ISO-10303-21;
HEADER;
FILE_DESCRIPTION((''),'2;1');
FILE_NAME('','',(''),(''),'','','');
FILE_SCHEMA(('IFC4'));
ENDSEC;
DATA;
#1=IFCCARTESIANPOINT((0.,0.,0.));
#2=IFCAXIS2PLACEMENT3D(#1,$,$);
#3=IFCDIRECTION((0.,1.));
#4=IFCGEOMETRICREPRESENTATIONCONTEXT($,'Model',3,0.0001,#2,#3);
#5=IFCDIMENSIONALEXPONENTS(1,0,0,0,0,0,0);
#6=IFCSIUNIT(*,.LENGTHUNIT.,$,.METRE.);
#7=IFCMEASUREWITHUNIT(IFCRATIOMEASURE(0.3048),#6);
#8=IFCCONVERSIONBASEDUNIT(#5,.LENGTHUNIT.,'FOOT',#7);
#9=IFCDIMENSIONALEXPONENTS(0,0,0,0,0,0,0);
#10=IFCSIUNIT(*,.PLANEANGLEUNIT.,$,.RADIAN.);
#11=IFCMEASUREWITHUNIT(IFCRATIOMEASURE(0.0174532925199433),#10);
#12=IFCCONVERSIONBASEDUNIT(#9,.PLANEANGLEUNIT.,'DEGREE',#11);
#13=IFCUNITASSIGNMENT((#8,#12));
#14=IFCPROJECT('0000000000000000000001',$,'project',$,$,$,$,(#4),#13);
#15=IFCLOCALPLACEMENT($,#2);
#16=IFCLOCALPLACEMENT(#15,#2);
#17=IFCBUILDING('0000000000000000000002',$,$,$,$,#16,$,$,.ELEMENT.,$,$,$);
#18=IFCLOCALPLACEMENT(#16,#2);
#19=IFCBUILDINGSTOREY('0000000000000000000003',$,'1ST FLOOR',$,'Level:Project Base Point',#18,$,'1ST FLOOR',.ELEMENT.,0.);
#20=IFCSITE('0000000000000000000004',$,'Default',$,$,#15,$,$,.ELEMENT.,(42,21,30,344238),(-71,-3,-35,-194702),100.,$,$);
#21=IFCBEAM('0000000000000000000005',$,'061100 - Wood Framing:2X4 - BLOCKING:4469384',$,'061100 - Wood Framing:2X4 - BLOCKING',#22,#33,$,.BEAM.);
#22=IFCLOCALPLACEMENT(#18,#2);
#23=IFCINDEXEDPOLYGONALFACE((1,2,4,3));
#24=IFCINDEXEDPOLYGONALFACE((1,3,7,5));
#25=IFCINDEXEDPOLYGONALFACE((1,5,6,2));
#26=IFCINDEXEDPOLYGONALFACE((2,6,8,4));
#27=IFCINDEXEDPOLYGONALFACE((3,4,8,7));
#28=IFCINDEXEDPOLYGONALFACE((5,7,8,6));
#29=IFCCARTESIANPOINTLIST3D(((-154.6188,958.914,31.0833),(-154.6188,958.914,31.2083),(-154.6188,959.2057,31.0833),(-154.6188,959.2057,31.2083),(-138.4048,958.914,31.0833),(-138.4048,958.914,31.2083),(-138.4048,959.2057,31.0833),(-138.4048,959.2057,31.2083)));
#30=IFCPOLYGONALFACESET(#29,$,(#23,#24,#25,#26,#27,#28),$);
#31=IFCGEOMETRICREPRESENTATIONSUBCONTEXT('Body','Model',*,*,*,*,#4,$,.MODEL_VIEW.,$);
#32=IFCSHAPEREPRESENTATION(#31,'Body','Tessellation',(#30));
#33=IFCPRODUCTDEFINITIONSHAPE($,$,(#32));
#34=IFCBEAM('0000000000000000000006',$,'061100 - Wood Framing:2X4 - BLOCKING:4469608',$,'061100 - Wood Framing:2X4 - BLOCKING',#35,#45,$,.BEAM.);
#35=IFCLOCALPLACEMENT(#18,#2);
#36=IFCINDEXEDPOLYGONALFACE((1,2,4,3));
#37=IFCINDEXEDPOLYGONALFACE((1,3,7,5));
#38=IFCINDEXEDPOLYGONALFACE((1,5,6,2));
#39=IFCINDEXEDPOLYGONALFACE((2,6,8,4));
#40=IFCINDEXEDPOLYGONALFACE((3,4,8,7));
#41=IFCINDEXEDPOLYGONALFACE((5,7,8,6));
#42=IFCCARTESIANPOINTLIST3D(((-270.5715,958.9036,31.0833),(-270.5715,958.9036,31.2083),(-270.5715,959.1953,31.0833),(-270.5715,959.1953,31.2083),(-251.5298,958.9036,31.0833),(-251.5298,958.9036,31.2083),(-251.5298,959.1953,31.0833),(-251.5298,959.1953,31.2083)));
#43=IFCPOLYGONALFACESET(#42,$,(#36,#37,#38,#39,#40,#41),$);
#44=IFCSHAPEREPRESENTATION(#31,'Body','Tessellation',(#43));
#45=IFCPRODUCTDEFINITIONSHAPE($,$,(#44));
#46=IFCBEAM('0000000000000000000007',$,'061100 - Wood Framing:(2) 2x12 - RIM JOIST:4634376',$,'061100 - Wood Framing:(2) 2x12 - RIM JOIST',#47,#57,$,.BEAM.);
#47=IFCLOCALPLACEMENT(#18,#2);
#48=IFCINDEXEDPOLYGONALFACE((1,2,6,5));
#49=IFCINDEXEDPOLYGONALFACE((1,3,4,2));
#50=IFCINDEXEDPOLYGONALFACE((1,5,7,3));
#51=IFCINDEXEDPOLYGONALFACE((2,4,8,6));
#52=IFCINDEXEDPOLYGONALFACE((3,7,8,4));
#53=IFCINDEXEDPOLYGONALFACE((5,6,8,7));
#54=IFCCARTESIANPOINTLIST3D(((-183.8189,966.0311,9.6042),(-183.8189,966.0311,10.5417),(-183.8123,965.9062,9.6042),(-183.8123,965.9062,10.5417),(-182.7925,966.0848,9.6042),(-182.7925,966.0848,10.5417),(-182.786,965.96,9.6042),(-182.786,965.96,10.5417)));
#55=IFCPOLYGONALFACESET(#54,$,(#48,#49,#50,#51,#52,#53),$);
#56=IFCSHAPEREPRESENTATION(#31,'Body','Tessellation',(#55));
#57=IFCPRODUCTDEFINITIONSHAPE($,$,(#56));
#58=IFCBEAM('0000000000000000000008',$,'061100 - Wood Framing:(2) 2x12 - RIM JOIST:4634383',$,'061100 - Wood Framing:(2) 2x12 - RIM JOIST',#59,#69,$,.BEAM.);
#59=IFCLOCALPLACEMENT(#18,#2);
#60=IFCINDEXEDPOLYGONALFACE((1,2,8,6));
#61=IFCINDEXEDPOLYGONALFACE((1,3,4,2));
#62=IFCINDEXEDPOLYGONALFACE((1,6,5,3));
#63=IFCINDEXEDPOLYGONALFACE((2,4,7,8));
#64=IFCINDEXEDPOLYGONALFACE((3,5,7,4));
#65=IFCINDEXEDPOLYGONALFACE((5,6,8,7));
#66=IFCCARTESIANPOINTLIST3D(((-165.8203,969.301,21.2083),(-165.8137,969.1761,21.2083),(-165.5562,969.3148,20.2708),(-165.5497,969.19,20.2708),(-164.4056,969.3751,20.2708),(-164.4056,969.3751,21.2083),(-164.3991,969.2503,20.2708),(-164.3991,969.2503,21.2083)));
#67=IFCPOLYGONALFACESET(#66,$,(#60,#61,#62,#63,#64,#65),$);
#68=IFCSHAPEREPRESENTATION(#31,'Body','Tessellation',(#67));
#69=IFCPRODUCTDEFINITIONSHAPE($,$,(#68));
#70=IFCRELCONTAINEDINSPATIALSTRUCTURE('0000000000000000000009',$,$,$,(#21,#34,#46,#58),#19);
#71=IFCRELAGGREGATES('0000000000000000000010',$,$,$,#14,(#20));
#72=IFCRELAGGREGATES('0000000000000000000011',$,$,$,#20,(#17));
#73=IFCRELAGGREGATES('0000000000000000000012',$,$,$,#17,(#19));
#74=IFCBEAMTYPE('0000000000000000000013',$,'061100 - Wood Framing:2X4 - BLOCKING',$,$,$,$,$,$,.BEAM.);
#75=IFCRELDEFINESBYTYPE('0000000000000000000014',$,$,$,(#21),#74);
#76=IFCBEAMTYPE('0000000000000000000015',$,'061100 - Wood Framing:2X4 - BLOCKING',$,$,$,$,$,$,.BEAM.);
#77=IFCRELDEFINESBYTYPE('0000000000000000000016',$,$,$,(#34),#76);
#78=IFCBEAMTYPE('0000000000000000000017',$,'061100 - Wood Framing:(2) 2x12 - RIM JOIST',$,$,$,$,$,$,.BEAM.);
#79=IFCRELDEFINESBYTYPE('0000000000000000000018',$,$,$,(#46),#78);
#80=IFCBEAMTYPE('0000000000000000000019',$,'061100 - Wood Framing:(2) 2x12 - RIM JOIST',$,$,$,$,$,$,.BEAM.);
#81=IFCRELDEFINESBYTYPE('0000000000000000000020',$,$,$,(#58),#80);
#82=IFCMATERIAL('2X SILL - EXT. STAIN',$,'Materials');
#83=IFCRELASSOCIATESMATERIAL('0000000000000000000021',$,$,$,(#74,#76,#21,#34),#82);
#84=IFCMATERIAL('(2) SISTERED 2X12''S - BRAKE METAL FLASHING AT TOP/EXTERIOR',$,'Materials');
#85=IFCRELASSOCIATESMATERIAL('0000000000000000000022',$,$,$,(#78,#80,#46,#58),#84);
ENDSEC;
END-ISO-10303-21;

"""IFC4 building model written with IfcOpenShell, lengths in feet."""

from ifc_helpers import new_model, entity, si_unit, converted_unit, direction, frame, frame_2d, origin, origin_2d_with_axis, place, context, subcontext, project, spatial, rectangle, extrude, clip, halfspace, source, transform, mapped, material, material_profile, profile_set, profile_usage, type_object, type_shapes, element, save


model = new_model("IFC4")

# Units and contexts
model_context = context("Model", 3, precision=0.0001, world=origin(), true_north=direction((0.0, 1.0)))
body_context = subcontext(model_context, "Body", "Model", "MODEL_VIEW")
ifc_project = project(units=[converted_unit("LENGTHUNIT", "FOOT", entity("IfcRatioMeasure", 0.3048), si_unit("LENGTHUNIT", "METRE"), dimensions=[1, 0, 0, 0, 0, 0, 0]), converted_unit("PLANEANGLEUNIT", "DEGREE", entity("IfcRatioMeasure", 0.0174532925199433), si_unit("PLANEANGLEUNIT", "RADIAN"), dimensions=[0, 0, 0, 0, 0, 0, 0])], contexts=[model_context])

# Site, building, storey
site_placement = place(None, origin())
site = spatial("IfcSite", under=ifc_project, at=site_placement, Name="Default", CompositionType="ELEMENT", RefLatitude=(42, 21, 30, 344238), RefLongitude=(-71, -3, -35, -194702), RefElevation=100.0)
building_placement = place(site_placement, origin())
building = spatial("IfcBuilding", under=site, at=building_placement, CompositionType="ELEMENT")
storey_placement = place(building_placement, origin())
storey = spatial("IfcBuildingStorey", under=building, at=storey_placement, Name="1ST FLOOR", ObjectType="Level:Project Base Point", LongName="1ST FLOOR", CompositionType="ELEMENT", Elevation=0.0)

# Beams
ifc_material_1 = material(Name="2X SILL - EXT. STAIN", Category="Materials")
ifc_material_profile_1 = material_profile(ifc_material_1, rectangle(XDim=0.125, YDim=0.2917, at=origin_2d_with_axis()), Name="2X4 - BLOCKING")
ifc_profile_set_1 = profile_set([ifc_material_profile_1], Name="2X4 - BLOCKING")
ifc_profile_usage_1 = profile_usage(ifc_profile_set_1, cardinal=8)
beam_type_1 = type_object("IfcBeamType", Name="061100 - Wood Framing:2X4 - BLOCKING", PredefinedType="BEAM", material=ifc_profile_set_1)
shared_shape_1 = source(origin(), body_context, "Body", "SweptSolid", [
    extrude(rectangle(XDim=0.125, YDim=0.2917, at=frame_2d((0.0, 0.0), x_axis=(1.0, 0.0))), frame((-154.6188, 959.0599, 31.1458), z_axis=(1.0, 0.0, 0.0), x_axis=(0.0, 0.0, -1.0)), (0.0, 0.0, 1.0), 16.2139),
])
type_shapes(beam_type_1, [shared_shape_1])
beam_1_placement = place(storey_placement, origin())
element("IfcBeam", 1, at=beam_1_placement, inside=storey, type_object=beam_type_1, material=ifc_profile_usage_1, Name="061100 - Wood Framing:2X4 - BLOCKING:4469384", ObjectType="061100 - Wood Framing:2X4 - BLOCKING", PredefinedType="BEAM", context=body_context, shape_type="MappedRepresentation", body=[
    mapped(shared_shape_1, transform((0.0, 0.0, 0.0), scale=1.0)),
])
ifc_profile_usage_2 = profile_usage(ifc_profile_set_1, cardinal=8)
beam_type_2 = type_object("IfcBeamType", Name="061100 - Wood Framing:2X4 - BLOCKING", PredefinedType="BEAM", material=ifc_profile_set_1)
shared_shape_2 = source(origin(), body_context, "Body", "SweptSolid", [
    extrude(rectangle(XDim=0.125, YDim=0.2917, at=frame_2d((0.0, 0.0), x_axis=(1.0, 0.0))), frame((-270.5715, 959.0494, 31.1458), z_axis=(1.0, 0.0, 0.0), x_axis=(0.0, 0.0, -1.0)), (0.0, 0.0, 1.0), 19.0417),
])
type_shapes(beam_type_2, [shared_shape_2])
beam_2_placement = place(storey_placement, origin())
element("IfcBeam", 2, at=beam_2_placement, inside=storey, type_object=beam_type_2, material=ifc_profile_usage_2, Name="061100 - Wood Framing:2X4 - BLOCKING:4469608", ObjectType="061100 - Wood Framing:2X4 - BLOCKING", PredefinedType="BEAM", context=body_context, shape_type="MappedRepresentation", body=[
    mapped(shared_shape_2, transform((0.0, 0.0, 0.0), scale=1.0)),
])
ifc_material_2 = material(Name="(2) SISTERED 2X12'S - BRAKE METAL FLASHING AT TOP/EXTERIOR", Category="Materials")
ifc_material_profile_2 = material_profile(ifc_material_2, rectangle(XDim=0.9375, YDim=0.125, at=frame_2d((0.0, 0.0), x_axis=(1.0, 0.0))), Name="(2) 2x12 - RIM JOIST")
ifc_profile_set_2 = profile_set([ifc_material_profile_2], Name="(2) 2x12 - RIM JOIST")
ifc_profile_usage_3 = profile_usage(ifc_profile_set_2, cardinal=2)
beam_type_3 = type_object("IfcBeamType", Name="061100 - Wood Framing:(2) 2x12 - RIM JOIST", PredefinedType="BEAM", material=ifc_profile_set_2)
shared_shape_3 = source(origin(), body_context, "Body", "SweptSolid", [
    extrude(rectangle(XDim=0.9375, YDim=0.125, at=origin_2d_with_axis()), frame((-183.8156, 965.9686, 10.0729), z_axis=(0.99863, 0.052336, 0.0), x_axis=(0.0, 0.0, 1.0)), (0.0, 0.0, 1.0), 1.0278),
])
type_shapes(beam_type_3, [shared_shape_3])
beam_3_placement = place(storey_placement, origin())
element("IfcBeam", 3, at=beam_3_placement, inside=storey, type_object=beam_type_3, material=ifc_profile_usage_3, Name="061100 - Wood Framing:(2) 2x12 - RIM JOIST:4634376", ObjectType="061100 - Wood Framing:(2) 2x12 - RIM JOIST", PredefinedType="BEAM", context=body_context, shape_type="MappedRepresentation", body=[
    mapped(shared_shape_3, transform((0.0, 0.0, 0.0), scale=1.0)),
])
ifc_profile_usage_4 = profile_usage(ifc_profile_set_2, cardinal=2)
beam_type_4 = type_object("IfcBeamType", Name="061100 - Wood Framing:(2) 2x12 - RIM JOIST", PredefinedType="BEAM", material=ifc_profile_set_2)
shared_shape_4 = source(origin(), body_context, "Body", "Clipping", [
    clip(extrude(rectangle(XDim=0.9375, YDim=0.125, at=frame_2d((0.0, 0.0), x_axis=(1.0, 0.0))), frame((-165.817, 969.2386, 20.7396), z_axis=(0.99863, 0.052336, 0.0), x_axis=(0.0, 0.0, 1.0)), (0.0, 0.0, 1.0), 1.4166), halfspace(frame((-165.2632, 966.0702, 19.8354), z_axis=(-0.961136, -0.050371, -0.27144), x_axis=(0.271068, 0.014206, -0.962455)), False)),
])
type_shapes(beam_type_4, [shared_shape_4])
beam_4_placement = place(storey_placement, origin())
element("IfcBeam", 4, at=beam_4_placement, inside=storey, type_object=beam_type_4, material=ifc_profile_usage_4, Name="061100 - Wood Framing:(2) 2x12 - RIM JOIST:4634383", ObjectType="061100 - Wood Framing:(2) 2x12 - RIM JOIST", PredefinedType="BEAM", context=body_context, shape_type="MappedRepresentation", body=[
    mapped(shared_shape_4, transform((0.0, 0.0, 0.0), scale=1.0)),
])

save(model, "model.ifc")
